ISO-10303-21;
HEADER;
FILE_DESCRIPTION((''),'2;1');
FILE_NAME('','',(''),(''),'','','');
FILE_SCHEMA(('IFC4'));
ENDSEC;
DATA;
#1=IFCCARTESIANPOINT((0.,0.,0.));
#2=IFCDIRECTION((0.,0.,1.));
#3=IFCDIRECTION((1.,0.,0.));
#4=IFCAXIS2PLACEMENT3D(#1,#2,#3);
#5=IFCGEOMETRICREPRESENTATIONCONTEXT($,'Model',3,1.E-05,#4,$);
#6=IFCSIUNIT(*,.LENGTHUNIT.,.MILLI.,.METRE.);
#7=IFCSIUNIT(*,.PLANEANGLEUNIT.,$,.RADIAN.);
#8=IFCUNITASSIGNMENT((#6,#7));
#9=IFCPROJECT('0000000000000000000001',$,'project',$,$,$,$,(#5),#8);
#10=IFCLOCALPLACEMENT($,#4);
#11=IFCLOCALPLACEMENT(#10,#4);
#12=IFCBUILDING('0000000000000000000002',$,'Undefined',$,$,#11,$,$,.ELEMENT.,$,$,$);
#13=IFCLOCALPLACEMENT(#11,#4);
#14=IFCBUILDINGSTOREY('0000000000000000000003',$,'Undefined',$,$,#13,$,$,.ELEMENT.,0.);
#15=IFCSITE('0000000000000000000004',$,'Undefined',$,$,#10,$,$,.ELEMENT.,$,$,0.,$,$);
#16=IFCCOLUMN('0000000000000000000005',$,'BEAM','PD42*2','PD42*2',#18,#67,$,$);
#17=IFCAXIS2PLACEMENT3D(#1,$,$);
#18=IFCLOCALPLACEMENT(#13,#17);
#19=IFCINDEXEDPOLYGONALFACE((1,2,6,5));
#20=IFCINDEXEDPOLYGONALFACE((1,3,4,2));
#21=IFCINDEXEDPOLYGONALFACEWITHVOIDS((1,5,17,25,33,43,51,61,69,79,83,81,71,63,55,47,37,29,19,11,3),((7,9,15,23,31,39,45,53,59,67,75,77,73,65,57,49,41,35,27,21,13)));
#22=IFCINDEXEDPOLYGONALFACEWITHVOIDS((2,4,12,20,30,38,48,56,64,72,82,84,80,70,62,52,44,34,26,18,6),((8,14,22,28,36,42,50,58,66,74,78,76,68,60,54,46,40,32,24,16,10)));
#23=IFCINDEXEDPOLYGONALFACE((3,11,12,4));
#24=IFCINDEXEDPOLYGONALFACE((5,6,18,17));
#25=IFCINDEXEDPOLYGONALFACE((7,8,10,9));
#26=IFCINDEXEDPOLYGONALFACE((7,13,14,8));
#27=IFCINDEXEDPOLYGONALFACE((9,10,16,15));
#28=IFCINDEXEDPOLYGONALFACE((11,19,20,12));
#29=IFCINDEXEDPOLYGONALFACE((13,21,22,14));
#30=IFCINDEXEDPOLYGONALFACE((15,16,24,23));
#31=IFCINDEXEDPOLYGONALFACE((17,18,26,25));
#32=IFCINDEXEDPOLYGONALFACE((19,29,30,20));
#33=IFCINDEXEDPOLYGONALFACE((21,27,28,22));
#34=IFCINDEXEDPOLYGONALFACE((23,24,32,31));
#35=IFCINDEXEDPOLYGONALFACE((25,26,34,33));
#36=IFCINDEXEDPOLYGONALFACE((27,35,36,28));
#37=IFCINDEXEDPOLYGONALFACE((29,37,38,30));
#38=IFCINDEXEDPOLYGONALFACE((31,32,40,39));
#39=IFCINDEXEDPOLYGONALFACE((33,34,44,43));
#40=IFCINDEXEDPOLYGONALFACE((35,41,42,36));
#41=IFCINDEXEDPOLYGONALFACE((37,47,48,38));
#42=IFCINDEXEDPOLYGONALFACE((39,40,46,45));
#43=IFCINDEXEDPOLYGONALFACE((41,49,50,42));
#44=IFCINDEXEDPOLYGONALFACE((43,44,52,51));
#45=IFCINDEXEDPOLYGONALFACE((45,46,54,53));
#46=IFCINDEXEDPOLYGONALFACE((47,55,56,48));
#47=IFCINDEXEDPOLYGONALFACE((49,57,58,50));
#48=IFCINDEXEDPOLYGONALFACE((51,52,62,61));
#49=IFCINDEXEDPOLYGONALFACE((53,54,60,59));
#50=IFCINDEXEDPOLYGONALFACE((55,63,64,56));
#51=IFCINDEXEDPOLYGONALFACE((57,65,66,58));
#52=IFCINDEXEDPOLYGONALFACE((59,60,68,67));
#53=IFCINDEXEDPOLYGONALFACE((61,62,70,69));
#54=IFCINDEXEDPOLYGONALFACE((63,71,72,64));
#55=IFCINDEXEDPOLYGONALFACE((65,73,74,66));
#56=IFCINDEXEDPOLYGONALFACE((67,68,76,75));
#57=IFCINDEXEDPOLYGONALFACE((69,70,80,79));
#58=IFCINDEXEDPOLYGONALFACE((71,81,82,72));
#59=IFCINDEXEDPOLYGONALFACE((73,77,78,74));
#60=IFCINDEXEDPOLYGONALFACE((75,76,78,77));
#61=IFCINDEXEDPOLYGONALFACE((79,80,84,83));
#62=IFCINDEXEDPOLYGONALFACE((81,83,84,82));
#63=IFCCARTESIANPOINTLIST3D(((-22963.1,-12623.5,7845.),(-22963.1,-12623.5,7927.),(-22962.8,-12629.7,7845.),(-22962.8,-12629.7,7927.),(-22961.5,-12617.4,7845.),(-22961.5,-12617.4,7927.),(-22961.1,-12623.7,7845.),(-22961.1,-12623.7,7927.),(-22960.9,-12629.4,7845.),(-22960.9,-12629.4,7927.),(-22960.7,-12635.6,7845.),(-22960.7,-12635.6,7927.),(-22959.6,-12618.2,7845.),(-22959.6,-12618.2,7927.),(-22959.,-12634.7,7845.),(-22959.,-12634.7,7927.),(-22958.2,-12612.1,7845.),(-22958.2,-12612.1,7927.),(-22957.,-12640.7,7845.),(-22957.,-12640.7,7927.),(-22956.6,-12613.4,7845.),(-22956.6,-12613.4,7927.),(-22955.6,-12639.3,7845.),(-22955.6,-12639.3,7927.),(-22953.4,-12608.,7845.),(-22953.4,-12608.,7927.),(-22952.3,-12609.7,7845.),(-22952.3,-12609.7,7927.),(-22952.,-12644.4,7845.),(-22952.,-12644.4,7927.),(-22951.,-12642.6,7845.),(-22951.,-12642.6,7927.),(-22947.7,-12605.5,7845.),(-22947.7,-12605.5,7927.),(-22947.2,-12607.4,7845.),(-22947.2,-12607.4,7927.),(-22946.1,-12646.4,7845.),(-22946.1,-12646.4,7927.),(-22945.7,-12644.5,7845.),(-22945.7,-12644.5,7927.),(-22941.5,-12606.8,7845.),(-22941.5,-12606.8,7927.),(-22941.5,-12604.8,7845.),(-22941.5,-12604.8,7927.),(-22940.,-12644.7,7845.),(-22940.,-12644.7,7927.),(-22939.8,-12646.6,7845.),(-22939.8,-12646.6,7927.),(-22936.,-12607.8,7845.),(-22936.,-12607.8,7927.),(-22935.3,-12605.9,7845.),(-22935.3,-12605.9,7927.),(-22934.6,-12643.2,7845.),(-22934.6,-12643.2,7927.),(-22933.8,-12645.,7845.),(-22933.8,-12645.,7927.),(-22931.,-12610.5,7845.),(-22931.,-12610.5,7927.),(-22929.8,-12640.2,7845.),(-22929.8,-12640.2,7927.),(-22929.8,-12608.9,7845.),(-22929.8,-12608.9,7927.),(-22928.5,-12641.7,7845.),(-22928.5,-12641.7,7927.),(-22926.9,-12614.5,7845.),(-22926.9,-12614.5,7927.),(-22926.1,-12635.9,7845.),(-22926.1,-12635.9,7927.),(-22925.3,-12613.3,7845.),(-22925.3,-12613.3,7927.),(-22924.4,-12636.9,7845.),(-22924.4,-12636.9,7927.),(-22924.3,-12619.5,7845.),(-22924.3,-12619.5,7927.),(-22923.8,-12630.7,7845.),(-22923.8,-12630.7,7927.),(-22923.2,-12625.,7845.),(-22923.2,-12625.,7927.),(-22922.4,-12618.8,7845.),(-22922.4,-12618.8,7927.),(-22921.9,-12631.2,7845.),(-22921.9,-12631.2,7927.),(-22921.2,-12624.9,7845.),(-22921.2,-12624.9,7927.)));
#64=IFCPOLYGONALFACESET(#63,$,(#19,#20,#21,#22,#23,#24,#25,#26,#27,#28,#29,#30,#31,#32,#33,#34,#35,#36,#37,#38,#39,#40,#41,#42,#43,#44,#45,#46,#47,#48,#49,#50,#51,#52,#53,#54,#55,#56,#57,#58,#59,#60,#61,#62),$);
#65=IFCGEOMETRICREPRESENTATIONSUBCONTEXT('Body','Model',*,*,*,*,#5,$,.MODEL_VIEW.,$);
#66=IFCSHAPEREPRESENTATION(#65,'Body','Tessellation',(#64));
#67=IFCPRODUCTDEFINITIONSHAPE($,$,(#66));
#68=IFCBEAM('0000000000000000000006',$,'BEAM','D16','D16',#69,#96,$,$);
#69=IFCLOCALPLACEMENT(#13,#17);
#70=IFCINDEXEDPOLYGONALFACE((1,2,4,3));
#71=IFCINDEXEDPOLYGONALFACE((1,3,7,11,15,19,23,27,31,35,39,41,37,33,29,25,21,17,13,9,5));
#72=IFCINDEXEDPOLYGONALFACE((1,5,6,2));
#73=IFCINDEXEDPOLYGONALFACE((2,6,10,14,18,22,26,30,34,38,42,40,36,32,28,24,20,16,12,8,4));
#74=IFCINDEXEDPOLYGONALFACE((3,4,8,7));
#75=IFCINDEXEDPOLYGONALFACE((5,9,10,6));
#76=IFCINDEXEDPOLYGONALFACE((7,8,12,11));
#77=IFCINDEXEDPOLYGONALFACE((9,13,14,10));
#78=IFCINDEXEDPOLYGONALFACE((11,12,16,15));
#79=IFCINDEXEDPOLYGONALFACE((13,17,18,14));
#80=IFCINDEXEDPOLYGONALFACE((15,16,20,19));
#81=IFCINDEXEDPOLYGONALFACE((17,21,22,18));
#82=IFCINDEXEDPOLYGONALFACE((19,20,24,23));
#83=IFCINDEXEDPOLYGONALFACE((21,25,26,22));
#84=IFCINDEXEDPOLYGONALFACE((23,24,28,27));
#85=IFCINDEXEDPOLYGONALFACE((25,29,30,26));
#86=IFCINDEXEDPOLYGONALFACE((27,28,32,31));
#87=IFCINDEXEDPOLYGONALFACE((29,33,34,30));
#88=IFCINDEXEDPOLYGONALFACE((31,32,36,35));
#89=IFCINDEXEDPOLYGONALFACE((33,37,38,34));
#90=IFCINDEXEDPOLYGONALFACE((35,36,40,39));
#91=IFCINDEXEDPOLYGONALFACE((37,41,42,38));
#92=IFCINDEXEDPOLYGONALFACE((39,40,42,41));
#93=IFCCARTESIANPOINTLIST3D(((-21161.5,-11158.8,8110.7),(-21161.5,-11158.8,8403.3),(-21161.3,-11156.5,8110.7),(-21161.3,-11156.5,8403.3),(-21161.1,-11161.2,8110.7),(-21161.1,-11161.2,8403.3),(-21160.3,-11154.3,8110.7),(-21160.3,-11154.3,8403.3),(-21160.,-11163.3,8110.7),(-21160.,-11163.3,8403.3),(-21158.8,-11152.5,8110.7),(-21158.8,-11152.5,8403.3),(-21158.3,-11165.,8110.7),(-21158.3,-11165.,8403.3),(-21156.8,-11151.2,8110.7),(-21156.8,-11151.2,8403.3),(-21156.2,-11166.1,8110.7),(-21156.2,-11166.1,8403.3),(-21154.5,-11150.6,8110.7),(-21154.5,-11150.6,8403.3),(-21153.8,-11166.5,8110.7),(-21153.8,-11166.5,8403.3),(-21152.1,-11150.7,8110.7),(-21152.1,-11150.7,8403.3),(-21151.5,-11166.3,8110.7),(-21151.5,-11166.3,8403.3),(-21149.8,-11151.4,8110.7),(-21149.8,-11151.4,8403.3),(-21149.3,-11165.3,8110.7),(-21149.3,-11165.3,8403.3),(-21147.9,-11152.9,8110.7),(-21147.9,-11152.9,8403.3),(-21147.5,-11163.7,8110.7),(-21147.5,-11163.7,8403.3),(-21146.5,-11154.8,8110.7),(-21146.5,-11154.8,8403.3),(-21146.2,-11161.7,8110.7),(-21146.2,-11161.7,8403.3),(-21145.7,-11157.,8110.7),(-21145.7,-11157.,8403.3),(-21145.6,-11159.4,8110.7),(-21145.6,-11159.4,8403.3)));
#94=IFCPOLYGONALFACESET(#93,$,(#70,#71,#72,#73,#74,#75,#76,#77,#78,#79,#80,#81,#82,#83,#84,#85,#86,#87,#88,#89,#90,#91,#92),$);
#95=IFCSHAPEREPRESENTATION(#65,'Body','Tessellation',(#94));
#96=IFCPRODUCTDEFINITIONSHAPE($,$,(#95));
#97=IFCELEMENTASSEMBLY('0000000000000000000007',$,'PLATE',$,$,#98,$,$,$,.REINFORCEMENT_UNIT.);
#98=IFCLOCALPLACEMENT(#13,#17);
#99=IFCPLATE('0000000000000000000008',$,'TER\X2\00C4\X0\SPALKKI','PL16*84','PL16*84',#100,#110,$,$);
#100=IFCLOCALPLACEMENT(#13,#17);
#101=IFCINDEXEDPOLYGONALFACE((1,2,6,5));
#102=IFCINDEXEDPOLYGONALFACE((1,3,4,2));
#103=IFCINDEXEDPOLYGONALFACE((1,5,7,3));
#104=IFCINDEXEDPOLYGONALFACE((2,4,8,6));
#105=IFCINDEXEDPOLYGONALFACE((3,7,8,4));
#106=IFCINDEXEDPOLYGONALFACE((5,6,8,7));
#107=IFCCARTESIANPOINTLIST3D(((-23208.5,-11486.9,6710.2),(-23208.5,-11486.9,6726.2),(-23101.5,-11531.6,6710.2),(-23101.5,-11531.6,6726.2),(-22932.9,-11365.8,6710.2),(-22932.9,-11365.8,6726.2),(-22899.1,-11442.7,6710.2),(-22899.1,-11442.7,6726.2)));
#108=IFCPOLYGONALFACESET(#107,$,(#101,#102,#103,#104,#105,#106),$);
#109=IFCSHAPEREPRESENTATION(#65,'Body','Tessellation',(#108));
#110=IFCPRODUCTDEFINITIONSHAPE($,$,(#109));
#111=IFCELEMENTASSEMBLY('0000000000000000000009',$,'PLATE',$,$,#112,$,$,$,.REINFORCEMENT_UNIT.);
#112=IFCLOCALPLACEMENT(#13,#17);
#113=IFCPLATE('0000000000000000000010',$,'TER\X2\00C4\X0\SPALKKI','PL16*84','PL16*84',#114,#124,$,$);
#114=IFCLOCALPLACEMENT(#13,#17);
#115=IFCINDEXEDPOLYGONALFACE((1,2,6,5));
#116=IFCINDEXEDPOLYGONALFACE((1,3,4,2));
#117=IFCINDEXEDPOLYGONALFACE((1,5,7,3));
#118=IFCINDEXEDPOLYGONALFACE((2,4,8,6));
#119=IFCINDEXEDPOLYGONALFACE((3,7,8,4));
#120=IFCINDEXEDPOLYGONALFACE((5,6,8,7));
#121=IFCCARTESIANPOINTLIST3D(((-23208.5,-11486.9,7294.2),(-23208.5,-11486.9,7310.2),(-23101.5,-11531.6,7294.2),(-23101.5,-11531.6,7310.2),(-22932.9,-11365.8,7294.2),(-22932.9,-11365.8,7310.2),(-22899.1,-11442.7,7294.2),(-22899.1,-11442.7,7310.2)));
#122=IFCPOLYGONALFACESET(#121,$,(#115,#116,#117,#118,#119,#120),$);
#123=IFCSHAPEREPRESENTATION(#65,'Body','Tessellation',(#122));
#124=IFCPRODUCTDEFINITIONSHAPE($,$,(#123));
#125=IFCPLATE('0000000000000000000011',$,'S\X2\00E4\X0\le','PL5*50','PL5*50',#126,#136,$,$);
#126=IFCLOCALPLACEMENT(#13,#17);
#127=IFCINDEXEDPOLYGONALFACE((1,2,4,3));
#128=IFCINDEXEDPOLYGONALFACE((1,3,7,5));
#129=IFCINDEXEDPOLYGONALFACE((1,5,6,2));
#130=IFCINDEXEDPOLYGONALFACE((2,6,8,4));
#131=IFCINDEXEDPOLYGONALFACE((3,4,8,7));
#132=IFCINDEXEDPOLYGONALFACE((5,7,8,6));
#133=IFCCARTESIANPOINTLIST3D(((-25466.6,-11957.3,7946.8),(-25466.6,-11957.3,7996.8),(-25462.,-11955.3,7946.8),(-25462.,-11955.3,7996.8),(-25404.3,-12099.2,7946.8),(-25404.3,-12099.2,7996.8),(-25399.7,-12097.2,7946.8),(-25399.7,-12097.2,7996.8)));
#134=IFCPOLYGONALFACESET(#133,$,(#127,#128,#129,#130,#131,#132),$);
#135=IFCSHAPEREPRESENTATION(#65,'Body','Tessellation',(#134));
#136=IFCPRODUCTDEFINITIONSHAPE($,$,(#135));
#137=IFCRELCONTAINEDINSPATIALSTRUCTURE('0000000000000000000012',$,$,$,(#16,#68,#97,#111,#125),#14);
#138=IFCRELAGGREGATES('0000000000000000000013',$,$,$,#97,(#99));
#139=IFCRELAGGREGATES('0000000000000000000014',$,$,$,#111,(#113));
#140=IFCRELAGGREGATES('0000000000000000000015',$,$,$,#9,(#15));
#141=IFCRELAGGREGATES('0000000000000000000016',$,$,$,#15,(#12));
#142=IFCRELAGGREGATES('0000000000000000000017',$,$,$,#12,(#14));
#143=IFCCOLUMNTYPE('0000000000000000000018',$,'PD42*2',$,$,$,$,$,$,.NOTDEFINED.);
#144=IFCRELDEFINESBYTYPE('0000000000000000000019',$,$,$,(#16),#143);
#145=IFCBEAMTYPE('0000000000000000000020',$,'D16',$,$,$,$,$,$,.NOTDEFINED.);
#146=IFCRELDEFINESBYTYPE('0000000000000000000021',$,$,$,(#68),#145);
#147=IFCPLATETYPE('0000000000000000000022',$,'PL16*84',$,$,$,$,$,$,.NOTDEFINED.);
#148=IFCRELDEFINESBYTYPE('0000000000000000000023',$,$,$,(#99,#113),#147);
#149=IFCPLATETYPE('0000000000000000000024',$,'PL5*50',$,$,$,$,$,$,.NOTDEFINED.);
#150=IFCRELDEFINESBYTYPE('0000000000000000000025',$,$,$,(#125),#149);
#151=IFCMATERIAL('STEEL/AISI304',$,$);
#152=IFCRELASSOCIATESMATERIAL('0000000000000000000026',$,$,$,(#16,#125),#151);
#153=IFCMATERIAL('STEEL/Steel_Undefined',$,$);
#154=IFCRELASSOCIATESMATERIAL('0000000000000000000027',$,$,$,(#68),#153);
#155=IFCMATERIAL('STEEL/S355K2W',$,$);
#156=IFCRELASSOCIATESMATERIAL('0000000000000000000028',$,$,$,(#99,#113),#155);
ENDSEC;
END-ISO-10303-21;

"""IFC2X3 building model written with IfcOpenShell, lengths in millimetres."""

from ifc_helpers import new_model, si_unit, frame, origin_with_axes, origin_2d_with_axis, place, context, subcontext, project, spatial, polyline, circle, hollow_circle, outline, extrude, material, type_object, element, aggregate, save


model = new_model("IFC2X3")

# Units and contexts
model_context = context("Model", 3, precision=1e-05, world=origin_with_axes())
body_context = subcontext(model_context, "Body", "Model", "MODEL_VIEW")
ifc_project = project(units=[si_unit("LENGTHUNIT", "METRE", prefix="MILLI"), si_unit("PLANEANGLEUNIT", "RADIAN")], contexts=[model_context])

# Site, building, storey
site_placement = place(None, origin_with_axes())
site = spatial("IfcSite", under=ifc_project, at=site_placement, Name="Undefined", CompositionType="ELEMENT", RefElevation=0.0)
building_placement = place(site_placement, origin_with_axes())
building = spatial("IfcBuilding", under=site, at=building_placement, Name="Undefined", CompositionType="ELEMENT")
storey_placement = place(building_placement, origin_with_axes())
storey = spatial("IfcBuildingStorey", under=building, at=storey_placement, Name="Undefined", CompositionType="ELEMENT", Elevation=0.0)

# Column
ifc_material_1 = material(Name="STEEL/AISI304")
column_type_1 = type_object("IfcColumnType", Name="PD42*2", PredefinedType="NOTDEFINED")
column_1_placement = place(storey_placement, frame((-22942.2, -12625.8, 7845.0), z_axis=(0.0, 0.0, 1.0), x_axis=(1.0, 0.0, 0.0)))
element("IfcColumn", 1, at=column_1_placement, inside=storey, type_object=column_type_1, material=ifc_material_1, Name="BEAM", Description="PD42*2", ObjectType="PD42*2", context=body_context, shape_type="SweptSolid", body=[
    extrude(hollow_circle(Radius=21.0, WallThickness=2.0, at=origin_2d_with_axis()), frame((0.0, 0.0, 82.0), z_axis=(0.0, 0.0, -1.0), x_axis=(0.402202, -0.915551, 0.0)), (0.0, 0.0, 1.0), 82.0),
])

# Shared definitions
ifc_material_2 = material(Name="STEEL/Steel_Undefined")

# Beam
beam_type_1 = type_object("IfcBeamType", Name="D16", PredefinedType="NOTDEFINED")
beam_1_placement = place(storey_placement, frame((-21153.5, -11158.5, 8403.3), z_axis=(-0.915553, -0.402197, 0.0), x_axis=(0.0, 0.0, -1.0)))
element("IfcBeam", 2, at=beam_1_placement, inside=storey, type_object=beam_type_1, material=ifc_material_2, Name="BEAM", Description="D16", ObjectType="D16", context=body_context, shape_type="SweptSolid", body=[
    extrude(circle(Radius=8.0, at=origin_2d_with_axis()), frame((292.6, 0.0, 0.0), z_axis=(-1.0, 0.0, 0.0), x_axis=(0.0, -1.0, 0.0)), (0.0, 0.0, 1.0), 292.6),
])

# Element assemblies, plates
assembly_1_placement = place(storey_placement, frame((-22899.1, -11442.7, 6718.2), z_axis=(-0.402202, 0.915551, 0.0), x_axis=(-0.915551, -0.402202, 0.0)))
assembly_1 = element("IfcElementAssembly", 3, at=assembly_1_placement, inside=storey, Name="PLATE", PredefinedType="REINFORCEMENT_UNIT")
ifc_material_3 = material(Name="STEEL/S355K2W")
plate_type_1 = type_object("IfcPlateType", Name="PL16*84", PredefinedType="NOTDEFINED")
plate_1_placement = place(storey_placement, frame((-22899.1, -11442.7, 6718.2), z_axis=(0.0, 0.0, -1.0), x_axis=(-0.915551, -0.402202, 0.0)))
plate_1 = element("IfcPlate", 4, at=plate_1_placement, type_object=plate_type_1, material=ifc_material_3, Name="TERÄSPALKKI", Description="PL16*84", ObjectType="PL16*84", context=body_context, shape_type="SweptSolid", body=[
    extrude(outline(polyline([(0.0, 0.0), (221.0, 0.0), (301.0, 84.0), (0.0, 84.0), (0.0, 0.0)])), frame((0.0, 0.0, -8.0), z_axis=(0.0, 0.0, 1.0), x_axis=(1.0, 0.0, 0.0)), (0.0, 0.0, 1.0), 16.0),
])
aggregate(assembly_1, [plate_1])
assembly_2_placement = place(storey_placement, frame((-22899.1, -11442.7, 7302.2), z_axis=(-0.402202, 0.915551, 0.0), x_axis=(-0.915551, -0.402202, 0.0)))
assembly_2 = element("IfcElementAssembly", 5, at=assembly_2_placement, inside=storey, Name="PLATE", PredefinedType="REINFORCEMENT_UNIT")
plate_2_placement = place(storey_placement, frame((-22899.1, -11442.7, 7302.2), z_axis=(0.0, 0.0, -1.0), x_axis=(-0.915551, -0.402202, 0.0)))
plate_2 = element("IfcPlate", 6, at=plate_2_placement, type_object=plate_type_1, material=ifc_material_3, Name="TERÄSPALKKI", Description="PL16*84", ObjectType="PL16*84", context=body_context, shape_type="SweptSolid", body=[
    extrude(outline(polyline([(0.0, 0.0), (221.0, 0.0), (301.0, 84.0), (0.0, 84.0), (0.0, 0.0)])), frame((0.0, 0.0, -8.0), z_axis=(0.0, 0.0, 1.0), x_axis=(1.0, 0.0, 0.0)), (0.0, 0.0, 1.0), 16.0),
])
aggregate(assembly_2, [plate_2])

# Plate
plate_type_2 = type_object("IfcPlateType", Name="PL5*50", PredefinedType="NOTDEFINED")
plate_3_placement = place(storey_placement, frame((-25402.0, -12098.2, 7996.8), z_axis=(0.915553, 0.402197, 0.0), x_axis=(0.0, 0.0, -1.0)))
element("IfcPlate", 7, at=plate_3_placement, inside=storey, type_object=plate_type_2, material=ifc_material_1, Name="Säle", Description="PL5*50", ObjectType="PL5*50", context=body_context, shape_type="SweptSolid", body=[
    extrude(outline(polyline([(0.0, 0.0), (50.0, 0.0), (50.0, 155.0), (0.0, 155.0), (0.0, 0.0)])), frame((0.0, 0.0, -2.5), z_axis=(0.0, 0.0, 1.0), x_axis=(1.0, 0.0, 0.0)), (0.0, 0.0, 1.0), 5.0),
])

save(model, "model.ifc")
